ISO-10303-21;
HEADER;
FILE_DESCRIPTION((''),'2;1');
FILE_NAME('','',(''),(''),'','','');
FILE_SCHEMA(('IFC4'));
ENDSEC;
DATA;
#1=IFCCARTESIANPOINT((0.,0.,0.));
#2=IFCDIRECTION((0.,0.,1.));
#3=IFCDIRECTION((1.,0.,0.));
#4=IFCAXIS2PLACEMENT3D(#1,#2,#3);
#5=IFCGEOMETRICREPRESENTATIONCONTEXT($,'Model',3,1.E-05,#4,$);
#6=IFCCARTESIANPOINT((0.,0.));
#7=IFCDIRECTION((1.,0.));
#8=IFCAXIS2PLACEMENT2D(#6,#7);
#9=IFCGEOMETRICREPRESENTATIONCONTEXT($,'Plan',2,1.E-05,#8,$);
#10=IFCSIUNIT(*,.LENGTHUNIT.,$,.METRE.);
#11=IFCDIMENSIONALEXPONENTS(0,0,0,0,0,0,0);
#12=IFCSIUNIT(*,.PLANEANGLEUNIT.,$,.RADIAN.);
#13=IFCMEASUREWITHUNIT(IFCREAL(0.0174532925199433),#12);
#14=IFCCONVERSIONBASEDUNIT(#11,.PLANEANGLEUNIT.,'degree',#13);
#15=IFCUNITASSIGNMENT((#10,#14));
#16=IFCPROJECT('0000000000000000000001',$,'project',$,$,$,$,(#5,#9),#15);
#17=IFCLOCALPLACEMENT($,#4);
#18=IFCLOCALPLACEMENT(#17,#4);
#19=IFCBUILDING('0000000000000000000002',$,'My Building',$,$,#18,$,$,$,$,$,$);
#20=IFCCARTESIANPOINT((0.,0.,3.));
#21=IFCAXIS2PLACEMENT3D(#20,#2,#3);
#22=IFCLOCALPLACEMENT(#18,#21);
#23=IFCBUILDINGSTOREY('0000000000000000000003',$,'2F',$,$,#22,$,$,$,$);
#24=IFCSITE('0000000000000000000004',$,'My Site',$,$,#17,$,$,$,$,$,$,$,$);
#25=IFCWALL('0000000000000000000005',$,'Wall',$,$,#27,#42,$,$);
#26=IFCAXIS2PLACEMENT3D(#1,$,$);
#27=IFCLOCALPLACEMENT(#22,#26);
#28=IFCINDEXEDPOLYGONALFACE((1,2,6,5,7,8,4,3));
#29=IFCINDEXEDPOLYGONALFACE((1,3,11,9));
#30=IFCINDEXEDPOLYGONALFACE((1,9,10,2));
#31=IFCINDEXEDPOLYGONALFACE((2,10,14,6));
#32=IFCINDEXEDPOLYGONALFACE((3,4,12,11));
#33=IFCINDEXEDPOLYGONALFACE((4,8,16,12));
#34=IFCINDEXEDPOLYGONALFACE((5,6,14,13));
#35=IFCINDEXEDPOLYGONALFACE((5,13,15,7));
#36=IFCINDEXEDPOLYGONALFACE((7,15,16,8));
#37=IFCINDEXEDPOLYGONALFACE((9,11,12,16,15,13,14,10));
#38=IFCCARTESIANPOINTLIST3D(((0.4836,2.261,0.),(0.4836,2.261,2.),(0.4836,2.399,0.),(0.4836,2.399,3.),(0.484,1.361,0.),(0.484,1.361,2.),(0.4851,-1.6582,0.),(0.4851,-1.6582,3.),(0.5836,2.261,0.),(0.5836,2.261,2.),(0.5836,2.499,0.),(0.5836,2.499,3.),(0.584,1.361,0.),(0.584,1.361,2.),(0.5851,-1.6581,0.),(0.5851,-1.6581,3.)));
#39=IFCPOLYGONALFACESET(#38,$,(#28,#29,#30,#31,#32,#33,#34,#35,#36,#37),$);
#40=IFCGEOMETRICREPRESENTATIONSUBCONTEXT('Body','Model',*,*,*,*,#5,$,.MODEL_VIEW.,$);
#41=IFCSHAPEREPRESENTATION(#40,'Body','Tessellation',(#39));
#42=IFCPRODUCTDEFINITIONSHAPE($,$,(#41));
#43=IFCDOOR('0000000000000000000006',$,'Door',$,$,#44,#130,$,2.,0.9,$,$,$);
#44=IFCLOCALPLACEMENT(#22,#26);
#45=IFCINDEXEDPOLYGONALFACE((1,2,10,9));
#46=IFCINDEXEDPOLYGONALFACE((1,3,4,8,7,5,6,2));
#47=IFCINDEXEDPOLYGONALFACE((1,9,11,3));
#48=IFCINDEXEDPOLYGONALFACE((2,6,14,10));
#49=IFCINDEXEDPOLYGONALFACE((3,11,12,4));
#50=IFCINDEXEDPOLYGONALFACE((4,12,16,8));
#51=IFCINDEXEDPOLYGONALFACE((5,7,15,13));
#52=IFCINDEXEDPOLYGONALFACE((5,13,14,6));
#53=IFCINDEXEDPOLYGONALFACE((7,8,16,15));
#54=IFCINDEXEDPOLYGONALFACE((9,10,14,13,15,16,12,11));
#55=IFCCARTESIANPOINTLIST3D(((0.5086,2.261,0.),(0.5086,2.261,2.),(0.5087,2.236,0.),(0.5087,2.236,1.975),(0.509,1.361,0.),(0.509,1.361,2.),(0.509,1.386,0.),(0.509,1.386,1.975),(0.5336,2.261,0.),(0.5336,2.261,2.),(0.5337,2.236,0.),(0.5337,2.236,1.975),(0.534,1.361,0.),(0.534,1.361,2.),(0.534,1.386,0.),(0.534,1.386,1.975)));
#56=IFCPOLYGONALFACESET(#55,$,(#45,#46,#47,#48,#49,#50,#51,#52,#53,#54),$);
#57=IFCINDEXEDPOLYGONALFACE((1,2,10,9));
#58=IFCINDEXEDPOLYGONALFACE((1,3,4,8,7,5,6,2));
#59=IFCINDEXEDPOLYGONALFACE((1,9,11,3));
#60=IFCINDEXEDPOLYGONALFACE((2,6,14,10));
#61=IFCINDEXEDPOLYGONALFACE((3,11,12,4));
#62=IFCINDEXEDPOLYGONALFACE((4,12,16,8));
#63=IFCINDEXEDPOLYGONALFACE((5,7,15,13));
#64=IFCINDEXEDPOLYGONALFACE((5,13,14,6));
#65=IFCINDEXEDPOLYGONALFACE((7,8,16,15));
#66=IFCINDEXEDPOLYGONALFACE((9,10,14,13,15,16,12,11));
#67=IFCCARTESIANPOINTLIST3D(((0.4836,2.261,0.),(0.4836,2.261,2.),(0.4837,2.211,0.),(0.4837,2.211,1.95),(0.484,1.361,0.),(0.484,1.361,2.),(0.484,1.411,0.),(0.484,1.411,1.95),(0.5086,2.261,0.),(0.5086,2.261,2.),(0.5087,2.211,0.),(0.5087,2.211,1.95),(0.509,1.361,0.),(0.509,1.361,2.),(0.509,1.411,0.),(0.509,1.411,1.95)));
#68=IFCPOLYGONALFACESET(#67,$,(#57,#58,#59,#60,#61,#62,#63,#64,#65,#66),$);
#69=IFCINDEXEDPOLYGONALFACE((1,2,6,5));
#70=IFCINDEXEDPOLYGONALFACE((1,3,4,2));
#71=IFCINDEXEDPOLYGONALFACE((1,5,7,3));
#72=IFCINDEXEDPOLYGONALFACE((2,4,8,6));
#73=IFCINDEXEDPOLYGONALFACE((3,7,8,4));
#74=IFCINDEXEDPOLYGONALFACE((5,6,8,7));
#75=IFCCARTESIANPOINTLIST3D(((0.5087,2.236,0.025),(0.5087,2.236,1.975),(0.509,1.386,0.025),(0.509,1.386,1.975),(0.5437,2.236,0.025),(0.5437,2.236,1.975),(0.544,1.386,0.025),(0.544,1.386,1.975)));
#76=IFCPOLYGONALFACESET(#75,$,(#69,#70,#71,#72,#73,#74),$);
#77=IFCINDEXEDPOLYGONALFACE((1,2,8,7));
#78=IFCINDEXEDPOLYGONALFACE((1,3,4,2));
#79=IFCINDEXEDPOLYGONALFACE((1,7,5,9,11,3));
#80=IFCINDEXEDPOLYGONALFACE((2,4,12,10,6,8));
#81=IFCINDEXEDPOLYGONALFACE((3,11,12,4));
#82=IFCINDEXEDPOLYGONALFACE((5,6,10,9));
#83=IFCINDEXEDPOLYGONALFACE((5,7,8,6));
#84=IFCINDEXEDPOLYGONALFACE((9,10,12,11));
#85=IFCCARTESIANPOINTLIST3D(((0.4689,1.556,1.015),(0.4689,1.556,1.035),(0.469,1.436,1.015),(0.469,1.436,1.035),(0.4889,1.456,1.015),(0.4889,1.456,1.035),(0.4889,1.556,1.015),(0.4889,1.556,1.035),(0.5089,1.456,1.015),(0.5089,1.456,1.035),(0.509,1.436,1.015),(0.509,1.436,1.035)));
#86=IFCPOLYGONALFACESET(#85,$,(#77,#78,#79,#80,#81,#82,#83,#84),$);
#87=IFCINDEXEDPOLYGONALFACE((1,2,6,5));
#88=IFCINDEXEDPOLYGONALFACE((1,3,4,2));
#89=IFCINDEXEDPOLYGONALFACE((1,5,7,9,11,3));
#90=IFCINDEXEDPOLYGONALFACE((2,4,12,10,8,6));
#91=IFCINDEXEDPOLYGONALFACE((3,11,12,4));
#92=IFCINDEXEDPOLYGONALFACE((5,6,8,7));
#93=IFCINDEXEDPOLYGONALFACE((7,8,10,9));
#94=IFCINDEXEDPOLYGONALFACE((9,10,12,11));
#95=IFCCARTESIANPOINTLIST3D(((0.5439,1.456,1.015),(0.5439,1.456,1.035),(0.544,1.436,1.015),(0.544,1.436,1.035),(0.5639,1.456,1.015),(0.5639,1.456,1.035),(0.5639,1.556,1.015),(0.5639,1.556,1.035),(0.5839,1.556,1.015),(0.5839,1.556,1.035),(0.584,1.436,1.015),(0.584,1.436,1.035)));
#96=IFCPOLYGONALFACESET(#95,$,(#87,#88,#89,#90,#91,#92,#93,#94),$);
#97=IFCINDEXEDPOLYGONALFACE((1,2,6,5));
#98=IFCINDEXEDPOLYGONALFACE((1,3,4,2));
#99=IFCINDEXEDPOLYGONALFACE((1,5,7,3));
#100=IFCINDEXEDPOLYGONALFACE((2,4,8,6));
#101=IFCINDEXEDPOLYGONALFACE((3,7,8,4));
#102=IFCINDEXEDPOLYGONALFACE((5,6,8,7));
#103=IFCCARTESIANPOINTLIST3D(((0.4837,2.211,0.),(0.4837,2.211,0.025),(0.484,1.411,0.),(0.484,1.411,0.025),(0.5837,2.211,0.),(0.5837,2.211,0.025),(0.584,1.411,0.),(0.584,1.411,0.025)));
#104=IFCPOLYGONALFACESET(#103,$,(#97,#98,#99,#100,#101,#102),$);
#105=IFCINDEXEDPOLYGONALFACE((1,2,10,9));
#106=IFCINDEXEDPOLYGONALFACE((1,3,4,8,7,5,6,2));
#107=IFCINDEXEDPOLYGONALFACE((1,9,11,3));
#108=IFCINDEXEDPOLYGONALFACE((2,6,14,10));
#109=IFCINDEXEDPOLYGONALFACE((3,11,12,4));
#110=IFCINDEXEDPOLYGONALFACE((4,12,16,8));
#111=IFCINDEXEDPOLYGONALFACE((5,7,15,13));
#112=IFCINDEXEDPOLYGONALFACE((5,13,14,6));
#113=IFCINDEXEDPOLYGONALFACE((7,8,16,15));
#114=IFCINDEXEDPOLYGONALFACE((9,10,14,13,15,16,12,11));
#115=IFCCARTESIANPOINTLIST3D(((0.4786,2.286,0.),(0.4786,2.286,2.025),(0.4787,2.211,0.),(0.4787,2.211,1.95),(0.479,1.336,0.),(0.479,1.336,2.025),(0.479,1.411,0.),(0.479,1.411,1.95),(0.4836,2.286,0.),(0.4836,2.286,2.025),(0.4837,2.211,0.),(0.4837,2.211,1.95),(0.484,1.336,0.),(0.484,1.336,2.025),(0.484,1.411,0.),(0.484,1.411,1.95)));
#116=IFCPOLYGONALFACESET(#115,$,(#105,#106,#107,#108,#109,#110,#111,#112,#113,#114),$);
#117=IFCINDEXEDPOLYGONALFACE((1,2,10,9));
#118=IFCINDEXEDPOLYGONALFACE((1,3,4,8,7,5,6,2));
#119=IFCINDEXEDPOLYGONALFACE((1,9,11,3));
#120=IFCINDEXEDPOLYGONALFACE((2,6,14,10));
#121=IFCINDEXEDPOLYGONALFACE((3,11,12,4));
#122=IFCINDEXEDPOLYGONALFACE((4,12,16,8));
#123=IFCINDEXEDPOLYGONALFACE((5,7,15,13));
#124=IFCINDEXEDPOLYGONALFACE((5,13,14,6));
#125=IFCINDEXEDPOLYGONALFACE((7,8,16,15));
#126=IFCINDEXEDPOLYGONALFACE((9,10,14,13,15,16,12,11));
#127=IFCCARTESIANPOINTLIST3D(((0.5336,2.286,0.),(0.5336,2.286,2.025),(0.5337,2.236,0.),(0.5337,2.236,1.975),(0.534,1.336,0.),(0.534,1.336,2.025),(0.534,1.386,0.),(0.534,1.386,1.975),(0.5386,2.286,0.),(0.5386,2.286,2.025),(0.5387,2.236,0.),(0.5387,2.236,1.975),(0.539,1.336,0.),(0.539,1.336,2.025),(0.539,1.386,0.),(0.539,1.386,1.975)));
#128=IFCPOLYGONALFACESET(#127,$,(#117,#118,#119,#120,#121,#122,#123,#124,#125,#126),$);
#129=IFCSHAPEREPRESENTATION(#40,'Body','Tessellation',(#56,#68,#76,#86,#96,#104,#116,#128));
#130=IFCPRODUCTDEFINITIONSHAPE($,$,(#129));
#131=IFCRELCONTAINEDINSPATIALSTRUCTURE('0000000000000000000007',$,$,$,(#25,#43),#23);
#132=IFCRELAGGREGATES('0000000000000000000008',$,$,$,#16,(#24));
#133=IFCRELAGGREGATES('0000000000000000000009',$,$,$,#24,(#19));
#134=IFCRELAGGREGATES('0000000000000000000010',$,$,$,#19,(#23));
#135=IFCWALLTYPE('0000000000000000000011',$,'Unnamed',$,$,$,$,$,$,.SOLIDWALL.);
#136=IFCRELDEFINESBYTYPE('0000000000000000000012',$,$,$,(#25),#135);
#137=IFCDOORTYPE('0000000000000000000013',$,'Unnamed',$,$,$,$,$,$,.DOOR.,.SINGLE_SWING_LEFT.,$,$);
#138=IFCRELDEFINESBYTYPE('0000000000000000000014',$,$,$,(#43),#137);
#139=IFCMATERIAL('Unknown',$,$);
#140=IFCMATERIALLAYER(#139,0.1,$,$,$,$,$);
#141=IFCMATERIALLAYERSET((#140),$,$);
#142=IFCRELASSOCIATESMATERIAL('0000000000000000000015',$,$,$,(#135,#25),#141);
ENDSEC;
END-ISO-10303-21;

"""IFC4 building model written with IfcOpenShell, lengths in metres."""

from ifc_helpers import new_model, entity, si_unit, converted_unit, frame, origin_with_axes, origin_2d_with_axis, place, context, subcontext, project, spatial, line, indexed_curve, outline, extrude, shape, source, transform, mapped, material, layer, layer_set, layer_usage, type_object, type_shapes, element, fill, save


model = new_model("IFC4")

# Units and contexts
model_context = context("Model", 3, precision=1e-05, world=origin_with_axes())
plan_context = context("Plan", 2, precision=1e-05, world=origin_2d_with_axis())
body_context_1 = subcontext(model_context, "Body", "Model", "MODEL_VIEW")
body_context_2 = subcontext(plan_context, "Body", "Plan", "PLAN_VIEW")
ifc_project = project(units=[si_unit("LENGTHUNIT", "METRE"), converted_unit("PLANEANGLEUNIT", "degree", entity("IfcReal", 0.0174532925199433), si_unit("PLANEANGLEUNIT", "RADIAN"), dimensions=[0, 0, 0, 0, 0, 0, 0])], contexts=[model_context, plan_context])

# Site, building, storey
site_placement = place(None, origin_with_axes())
site = spatial("IfcSite", under=ifc_project, at=site_placement, Name="My Site")
building_placement = place(site_placement, origin_with_axes())
building = spatial("IfcBuilding", under=site, at=building_placement, Name="My Building")
storey_placement = place(building_placement, frame((0.0, 0.0, 3.0), z_axis=(0.0, 0.0, 1.0), x_axis=(1.0, 0.0, 0.0)))
storey = spatial("IfcBuildingStorey", under=building, at=storey_placement, Name="2F")

# Shared definitions
ifc_material = material(Name="Unknown")

# Wall, opening, door
ifc_layer = layer(ifc_material, 0.1)
ifc_layer_set = layer_set([ifc_layer])
ifc_layer_usage_1 = layer_usage(ifc_layer_set, "AXIS2", "POSITIVE", 0.0)
wall_type = type_object("IfcWallType", Name="Unnamed", PredefinedType="SOLIDWALL", material=ifc_layer_set)
wall_1_placement = place(storey_placement, frame((0.4836, 2.399, 0.0), z_axis=(0.0, 0.0, 1.0), x_axis=(0.000374, -1.0, 0.0)))
wall_1 = element("IfcWall", 1, at=wall_1_placement, inside=storey, type_object=wall_type, material=ifc_layer_usage_1, Name="Wall", context=body_context_1, shape_type="SweptSolid", body=[
    extrude(outline(indexed_curve([(0.0, 0.0), (-0.1, 0.1), (4.0571, 0.1), (4.0571, 0.0)], segments=[line(1, 2, 3, 4, 1)])), origin_with_axes(), (0.0, 0.0, 1.0), 3.0),
])
shared_shape_1 = source(origin_with_axes(), body_context_1, "Body", "SweptSolid", [
    extrude(outline(indexed_curve([(0.0, 0.0), (0.9, 0.0), (0.9, 2.0), (0.0, 2.0)], segments=[line(1, 2, 3, 4, 1)])), frame((0.0, -0.6, 0.0), z_axis=(0.0, -1.0, 0.0), x_axis=(1.0, 0.0, 0.0)), (0.0, 0.0, -1.0), 1.2),
])
opening_1_placement = place(wall_1_placement, frame((0.138, 0.0, 0.0), z_axis=(0.0, 0.0, 1.0), x_axis=(1.0, 0.0, 0.0)))
opening_1 = element("IfcOpeningElement", 2, at=opening_1_placement, cuts=wall_1, PredefinedType="OPENING", context=body_context_1, shape_type="MappedRepresentation", body=[
    mapped(shared_shape_1, transform((0.0, 0.0, 0.0), x_axis=(1.0, 0.0, 0.0), y_axis=(0.0, 1.0, 0.0), z_axis=(0.0, 0.0, 1.0), scale=1.0)),
])
door_type_1 = type_object("IfcDoorType", Name="Unnamed", OperationType="SINGLE_SWING_LEFT", PredefinedType="DOOR")
shared_shape_2 = source(origin_with_axes(), body_context_1, "Body", "SweptSolid", [
    extrude(outline(indexed_curve([(0.0, 0.0), (0.0, 2.0), (0.9, 2.0), (0.9, 0.0), (0.875, 0.0), (0.875, 1.975), (0.025, 1.975), (0.025, 0.0)], segments=[line(1, 2, 3, 4, 5, 6, 7, 8, 1)])), frame((0.0, 0.025, 0.0), z_axis=(0.0, -1.0, 0.0), x_axis=(1.0, 0.0, 0.0)), (0.0, 0.0, -1.0), 0.025),
    extrude(outline(indexed_curve([(0.0, 0.0), (0.0, 2.0), (0.9, 2.0), (0.9, 0.0), (0.85, 0.0), (0.85, 1.95), (0.05, 1.95), (0.05, 0.0)], segments=[line(1, 2, 3, 4, 5, 6, 7, 8, 1)])), frame((0.0, 0.0, 0.0), z_axis=(0.0, -1.0, 0.0), x_axis=(1.0, 0.0, 0.0)), (0.0, 0.0, -1.0), 0.025),
    extrude(outline(indexed_curve([(0.0, 0.0), (0.85, 0.0), (0.85, 0.035), (0.0, 0.035)], segments=[line(1, 2, 3, 4, 1)])), frame((0.025, 0.025, 0.025), z_axis=(0.0, 0.0, 1.0), x_axis=(1.0, 0.0, 0.0)), (0.0, 0.0, 1.0), 1.95),
    extrude(outline(indexed_curve([(0.0, 0.0), (0.0, -0.04), (-0.12, -0.04), (-0.12, -0.02), (-0.02, -0.02), (-0.02, 0.0)], segments=[line(1, 2, 3, 4, 5, 6, 1)])), frame((0.825, 0.025, 1.015), z_axis=(0.0, 0.0, 1.0), x_axis=(1.0, 0.0, 0.0)), (0.0, 0.0, 1.0), 0.02),
    extrude(outline(indexed_curve([(0.0, 0.0), (0.0, 0.04), (-0.12, 0.04), (-0.12, 0.02), (-0.02, 0.02), (-0.02, 0.0)], segments=[line(1, 2, 3, 4, 5, 6, 1)])), frame((0.825, 0.06, 1.015), z_axis=(0.0, 0.0, 1.0), x_axis=(1.0, 0.0, 0.0)), (0.0, 0.0, 1.0), 0.02),
    extrude(outline(indexed_curve([(0.0, 0.0), (0.8, 0.0), (0.8, 0.1), (0.0, 0.1)], segments=[line(1, 2, 3, 4, 1)])), frame((0.05, 0.0, 0.0), z_axis=(0.0, 0.0, 1.0), x_axis=(1.0, 0.0, 0.0)), (0.0, 0.0, 1.0), 0.025),
    extrude(outline(indexed_curve([(0.0, 0.0), (0.0, 2.025), (0.95, 2.025), (0.95, 0.0), (0.875, 0.0), (0.875, 1.95), (0.075, 1.95), (0.075, 0.0)], segments=[line(1, 2, 3, 4, 5, 6, 7, 8, 1)])), frame((-0.025, -0.005, 0.0), z_axis=(0.0, -1.0, 0.0), x_axis=(1.0, 0.0, 0.0)), (0.0, 0.0, -1.0), 0.005),
    extrude(outline(indexed_curve([(0.0, 0.0), (0.0, 2.025), (0.95, 2.025), (0.95, 0.0), (0.9, 0.0), (0.9, 1.975), (0.05, 1.975), (0.05, 0.0)], segments=[line(1, 2, 3, 4, 5, 6, 7, 8, 1)])), frame((-0.025, 0.05, 0.0), z_axis=(0.0, -1.0, 0.0), x_axis=(1.0, 0.0, 0.0)), (0.0, 0.0, -1.0), 0.005),
])
shared_shape_3 = source(origin_with_axes(), body_context_2, "Body", "Curve2D", [
    entity("IfcIndexedPolyCurve", entity("IfcCartesianPointList2D", [[0.0, 0.0], [0.0, 0.05], [0.025, 0.05], [0.025, 0.025], [0.05, 0.025], [0.05, 0.0]]), [entity("IfcLineIndex", [1, 2, 3, 4, 5, 6, 1])]),
    entity("IfcIndexedPolyCurve", entity("IfcCartesianPointList2D", [[0.9, 0.0], [0.9, 0.05], [0.875, 0.05], [0.875, 0.025], [0.85, 0.025], [0.85, 0.0]]), [entity("IfcLineIndex", [1, 2, 3, 4, 5, 6, 1])]),
    entity("IfcTrimmedCurve", entity("IfcEllipse", entity("IfcAxis2Placement2D", entity("IfcCartesianPoint", [0.06, 0.05]), entity("IfcDirection", [1.0, 0.0])), 0.815, 0.85), [entity("IfcCartesianPoint", [0.875, 0.05])], [entity("IfcCartesianPoint", [0.06, 0.9])], True, "CARTESIAN"),
    entity("IfcIndexedPolyCurve", entity("IfcCartesianPointList2D", [[0.025, 0.05], [0.06, 0.05], [0.06, 0.9], [0.025, 0.9]]), [entity("IfcLineIndex", [1, 2, 3, 4, 1])]),
])
type_shapes(door_type_1, [shared_shape_2, shared_shape_3])
door_1_placement = place(opening_1_placement, frame((0.0, 0.0, 0.0), z_axis=(0.0, 0.0, 1.0), x_axis=(1.0, 0.0, 0.0)))
door_1 = element("IfcDoor", 3, at=door_1_placement, inside=storey, type_object=door_type_1, Name="Door", OverallHeight=2.0, OverallWidth=0.9, shapes=[
    shape(body_context_1, "Body", "MappedRepresentation", [mapped(shared_shape_2, transform((0.0, 0.0, 0.0), x_axis=(1.0, 0.0, 0.0), y_axis=(0.0, 1.0, 0.0), z_axis=(0.0, 0.0, 1.0), scale=1.0))]),
    shape(body_context_2, "Body", "MappedRepresentation", [mapped(shared_shape_3, transform((0.0, 0.0, 0.0), x_axis=(1.0, 0.0, 0.0), y_axis=(0.0, 1.0, 0.0), z_axis=(0.0, 0.0, 1.0), scale=1.0))]),
])
fill(opening_1, door_1)

save(model, "model.ifc")
